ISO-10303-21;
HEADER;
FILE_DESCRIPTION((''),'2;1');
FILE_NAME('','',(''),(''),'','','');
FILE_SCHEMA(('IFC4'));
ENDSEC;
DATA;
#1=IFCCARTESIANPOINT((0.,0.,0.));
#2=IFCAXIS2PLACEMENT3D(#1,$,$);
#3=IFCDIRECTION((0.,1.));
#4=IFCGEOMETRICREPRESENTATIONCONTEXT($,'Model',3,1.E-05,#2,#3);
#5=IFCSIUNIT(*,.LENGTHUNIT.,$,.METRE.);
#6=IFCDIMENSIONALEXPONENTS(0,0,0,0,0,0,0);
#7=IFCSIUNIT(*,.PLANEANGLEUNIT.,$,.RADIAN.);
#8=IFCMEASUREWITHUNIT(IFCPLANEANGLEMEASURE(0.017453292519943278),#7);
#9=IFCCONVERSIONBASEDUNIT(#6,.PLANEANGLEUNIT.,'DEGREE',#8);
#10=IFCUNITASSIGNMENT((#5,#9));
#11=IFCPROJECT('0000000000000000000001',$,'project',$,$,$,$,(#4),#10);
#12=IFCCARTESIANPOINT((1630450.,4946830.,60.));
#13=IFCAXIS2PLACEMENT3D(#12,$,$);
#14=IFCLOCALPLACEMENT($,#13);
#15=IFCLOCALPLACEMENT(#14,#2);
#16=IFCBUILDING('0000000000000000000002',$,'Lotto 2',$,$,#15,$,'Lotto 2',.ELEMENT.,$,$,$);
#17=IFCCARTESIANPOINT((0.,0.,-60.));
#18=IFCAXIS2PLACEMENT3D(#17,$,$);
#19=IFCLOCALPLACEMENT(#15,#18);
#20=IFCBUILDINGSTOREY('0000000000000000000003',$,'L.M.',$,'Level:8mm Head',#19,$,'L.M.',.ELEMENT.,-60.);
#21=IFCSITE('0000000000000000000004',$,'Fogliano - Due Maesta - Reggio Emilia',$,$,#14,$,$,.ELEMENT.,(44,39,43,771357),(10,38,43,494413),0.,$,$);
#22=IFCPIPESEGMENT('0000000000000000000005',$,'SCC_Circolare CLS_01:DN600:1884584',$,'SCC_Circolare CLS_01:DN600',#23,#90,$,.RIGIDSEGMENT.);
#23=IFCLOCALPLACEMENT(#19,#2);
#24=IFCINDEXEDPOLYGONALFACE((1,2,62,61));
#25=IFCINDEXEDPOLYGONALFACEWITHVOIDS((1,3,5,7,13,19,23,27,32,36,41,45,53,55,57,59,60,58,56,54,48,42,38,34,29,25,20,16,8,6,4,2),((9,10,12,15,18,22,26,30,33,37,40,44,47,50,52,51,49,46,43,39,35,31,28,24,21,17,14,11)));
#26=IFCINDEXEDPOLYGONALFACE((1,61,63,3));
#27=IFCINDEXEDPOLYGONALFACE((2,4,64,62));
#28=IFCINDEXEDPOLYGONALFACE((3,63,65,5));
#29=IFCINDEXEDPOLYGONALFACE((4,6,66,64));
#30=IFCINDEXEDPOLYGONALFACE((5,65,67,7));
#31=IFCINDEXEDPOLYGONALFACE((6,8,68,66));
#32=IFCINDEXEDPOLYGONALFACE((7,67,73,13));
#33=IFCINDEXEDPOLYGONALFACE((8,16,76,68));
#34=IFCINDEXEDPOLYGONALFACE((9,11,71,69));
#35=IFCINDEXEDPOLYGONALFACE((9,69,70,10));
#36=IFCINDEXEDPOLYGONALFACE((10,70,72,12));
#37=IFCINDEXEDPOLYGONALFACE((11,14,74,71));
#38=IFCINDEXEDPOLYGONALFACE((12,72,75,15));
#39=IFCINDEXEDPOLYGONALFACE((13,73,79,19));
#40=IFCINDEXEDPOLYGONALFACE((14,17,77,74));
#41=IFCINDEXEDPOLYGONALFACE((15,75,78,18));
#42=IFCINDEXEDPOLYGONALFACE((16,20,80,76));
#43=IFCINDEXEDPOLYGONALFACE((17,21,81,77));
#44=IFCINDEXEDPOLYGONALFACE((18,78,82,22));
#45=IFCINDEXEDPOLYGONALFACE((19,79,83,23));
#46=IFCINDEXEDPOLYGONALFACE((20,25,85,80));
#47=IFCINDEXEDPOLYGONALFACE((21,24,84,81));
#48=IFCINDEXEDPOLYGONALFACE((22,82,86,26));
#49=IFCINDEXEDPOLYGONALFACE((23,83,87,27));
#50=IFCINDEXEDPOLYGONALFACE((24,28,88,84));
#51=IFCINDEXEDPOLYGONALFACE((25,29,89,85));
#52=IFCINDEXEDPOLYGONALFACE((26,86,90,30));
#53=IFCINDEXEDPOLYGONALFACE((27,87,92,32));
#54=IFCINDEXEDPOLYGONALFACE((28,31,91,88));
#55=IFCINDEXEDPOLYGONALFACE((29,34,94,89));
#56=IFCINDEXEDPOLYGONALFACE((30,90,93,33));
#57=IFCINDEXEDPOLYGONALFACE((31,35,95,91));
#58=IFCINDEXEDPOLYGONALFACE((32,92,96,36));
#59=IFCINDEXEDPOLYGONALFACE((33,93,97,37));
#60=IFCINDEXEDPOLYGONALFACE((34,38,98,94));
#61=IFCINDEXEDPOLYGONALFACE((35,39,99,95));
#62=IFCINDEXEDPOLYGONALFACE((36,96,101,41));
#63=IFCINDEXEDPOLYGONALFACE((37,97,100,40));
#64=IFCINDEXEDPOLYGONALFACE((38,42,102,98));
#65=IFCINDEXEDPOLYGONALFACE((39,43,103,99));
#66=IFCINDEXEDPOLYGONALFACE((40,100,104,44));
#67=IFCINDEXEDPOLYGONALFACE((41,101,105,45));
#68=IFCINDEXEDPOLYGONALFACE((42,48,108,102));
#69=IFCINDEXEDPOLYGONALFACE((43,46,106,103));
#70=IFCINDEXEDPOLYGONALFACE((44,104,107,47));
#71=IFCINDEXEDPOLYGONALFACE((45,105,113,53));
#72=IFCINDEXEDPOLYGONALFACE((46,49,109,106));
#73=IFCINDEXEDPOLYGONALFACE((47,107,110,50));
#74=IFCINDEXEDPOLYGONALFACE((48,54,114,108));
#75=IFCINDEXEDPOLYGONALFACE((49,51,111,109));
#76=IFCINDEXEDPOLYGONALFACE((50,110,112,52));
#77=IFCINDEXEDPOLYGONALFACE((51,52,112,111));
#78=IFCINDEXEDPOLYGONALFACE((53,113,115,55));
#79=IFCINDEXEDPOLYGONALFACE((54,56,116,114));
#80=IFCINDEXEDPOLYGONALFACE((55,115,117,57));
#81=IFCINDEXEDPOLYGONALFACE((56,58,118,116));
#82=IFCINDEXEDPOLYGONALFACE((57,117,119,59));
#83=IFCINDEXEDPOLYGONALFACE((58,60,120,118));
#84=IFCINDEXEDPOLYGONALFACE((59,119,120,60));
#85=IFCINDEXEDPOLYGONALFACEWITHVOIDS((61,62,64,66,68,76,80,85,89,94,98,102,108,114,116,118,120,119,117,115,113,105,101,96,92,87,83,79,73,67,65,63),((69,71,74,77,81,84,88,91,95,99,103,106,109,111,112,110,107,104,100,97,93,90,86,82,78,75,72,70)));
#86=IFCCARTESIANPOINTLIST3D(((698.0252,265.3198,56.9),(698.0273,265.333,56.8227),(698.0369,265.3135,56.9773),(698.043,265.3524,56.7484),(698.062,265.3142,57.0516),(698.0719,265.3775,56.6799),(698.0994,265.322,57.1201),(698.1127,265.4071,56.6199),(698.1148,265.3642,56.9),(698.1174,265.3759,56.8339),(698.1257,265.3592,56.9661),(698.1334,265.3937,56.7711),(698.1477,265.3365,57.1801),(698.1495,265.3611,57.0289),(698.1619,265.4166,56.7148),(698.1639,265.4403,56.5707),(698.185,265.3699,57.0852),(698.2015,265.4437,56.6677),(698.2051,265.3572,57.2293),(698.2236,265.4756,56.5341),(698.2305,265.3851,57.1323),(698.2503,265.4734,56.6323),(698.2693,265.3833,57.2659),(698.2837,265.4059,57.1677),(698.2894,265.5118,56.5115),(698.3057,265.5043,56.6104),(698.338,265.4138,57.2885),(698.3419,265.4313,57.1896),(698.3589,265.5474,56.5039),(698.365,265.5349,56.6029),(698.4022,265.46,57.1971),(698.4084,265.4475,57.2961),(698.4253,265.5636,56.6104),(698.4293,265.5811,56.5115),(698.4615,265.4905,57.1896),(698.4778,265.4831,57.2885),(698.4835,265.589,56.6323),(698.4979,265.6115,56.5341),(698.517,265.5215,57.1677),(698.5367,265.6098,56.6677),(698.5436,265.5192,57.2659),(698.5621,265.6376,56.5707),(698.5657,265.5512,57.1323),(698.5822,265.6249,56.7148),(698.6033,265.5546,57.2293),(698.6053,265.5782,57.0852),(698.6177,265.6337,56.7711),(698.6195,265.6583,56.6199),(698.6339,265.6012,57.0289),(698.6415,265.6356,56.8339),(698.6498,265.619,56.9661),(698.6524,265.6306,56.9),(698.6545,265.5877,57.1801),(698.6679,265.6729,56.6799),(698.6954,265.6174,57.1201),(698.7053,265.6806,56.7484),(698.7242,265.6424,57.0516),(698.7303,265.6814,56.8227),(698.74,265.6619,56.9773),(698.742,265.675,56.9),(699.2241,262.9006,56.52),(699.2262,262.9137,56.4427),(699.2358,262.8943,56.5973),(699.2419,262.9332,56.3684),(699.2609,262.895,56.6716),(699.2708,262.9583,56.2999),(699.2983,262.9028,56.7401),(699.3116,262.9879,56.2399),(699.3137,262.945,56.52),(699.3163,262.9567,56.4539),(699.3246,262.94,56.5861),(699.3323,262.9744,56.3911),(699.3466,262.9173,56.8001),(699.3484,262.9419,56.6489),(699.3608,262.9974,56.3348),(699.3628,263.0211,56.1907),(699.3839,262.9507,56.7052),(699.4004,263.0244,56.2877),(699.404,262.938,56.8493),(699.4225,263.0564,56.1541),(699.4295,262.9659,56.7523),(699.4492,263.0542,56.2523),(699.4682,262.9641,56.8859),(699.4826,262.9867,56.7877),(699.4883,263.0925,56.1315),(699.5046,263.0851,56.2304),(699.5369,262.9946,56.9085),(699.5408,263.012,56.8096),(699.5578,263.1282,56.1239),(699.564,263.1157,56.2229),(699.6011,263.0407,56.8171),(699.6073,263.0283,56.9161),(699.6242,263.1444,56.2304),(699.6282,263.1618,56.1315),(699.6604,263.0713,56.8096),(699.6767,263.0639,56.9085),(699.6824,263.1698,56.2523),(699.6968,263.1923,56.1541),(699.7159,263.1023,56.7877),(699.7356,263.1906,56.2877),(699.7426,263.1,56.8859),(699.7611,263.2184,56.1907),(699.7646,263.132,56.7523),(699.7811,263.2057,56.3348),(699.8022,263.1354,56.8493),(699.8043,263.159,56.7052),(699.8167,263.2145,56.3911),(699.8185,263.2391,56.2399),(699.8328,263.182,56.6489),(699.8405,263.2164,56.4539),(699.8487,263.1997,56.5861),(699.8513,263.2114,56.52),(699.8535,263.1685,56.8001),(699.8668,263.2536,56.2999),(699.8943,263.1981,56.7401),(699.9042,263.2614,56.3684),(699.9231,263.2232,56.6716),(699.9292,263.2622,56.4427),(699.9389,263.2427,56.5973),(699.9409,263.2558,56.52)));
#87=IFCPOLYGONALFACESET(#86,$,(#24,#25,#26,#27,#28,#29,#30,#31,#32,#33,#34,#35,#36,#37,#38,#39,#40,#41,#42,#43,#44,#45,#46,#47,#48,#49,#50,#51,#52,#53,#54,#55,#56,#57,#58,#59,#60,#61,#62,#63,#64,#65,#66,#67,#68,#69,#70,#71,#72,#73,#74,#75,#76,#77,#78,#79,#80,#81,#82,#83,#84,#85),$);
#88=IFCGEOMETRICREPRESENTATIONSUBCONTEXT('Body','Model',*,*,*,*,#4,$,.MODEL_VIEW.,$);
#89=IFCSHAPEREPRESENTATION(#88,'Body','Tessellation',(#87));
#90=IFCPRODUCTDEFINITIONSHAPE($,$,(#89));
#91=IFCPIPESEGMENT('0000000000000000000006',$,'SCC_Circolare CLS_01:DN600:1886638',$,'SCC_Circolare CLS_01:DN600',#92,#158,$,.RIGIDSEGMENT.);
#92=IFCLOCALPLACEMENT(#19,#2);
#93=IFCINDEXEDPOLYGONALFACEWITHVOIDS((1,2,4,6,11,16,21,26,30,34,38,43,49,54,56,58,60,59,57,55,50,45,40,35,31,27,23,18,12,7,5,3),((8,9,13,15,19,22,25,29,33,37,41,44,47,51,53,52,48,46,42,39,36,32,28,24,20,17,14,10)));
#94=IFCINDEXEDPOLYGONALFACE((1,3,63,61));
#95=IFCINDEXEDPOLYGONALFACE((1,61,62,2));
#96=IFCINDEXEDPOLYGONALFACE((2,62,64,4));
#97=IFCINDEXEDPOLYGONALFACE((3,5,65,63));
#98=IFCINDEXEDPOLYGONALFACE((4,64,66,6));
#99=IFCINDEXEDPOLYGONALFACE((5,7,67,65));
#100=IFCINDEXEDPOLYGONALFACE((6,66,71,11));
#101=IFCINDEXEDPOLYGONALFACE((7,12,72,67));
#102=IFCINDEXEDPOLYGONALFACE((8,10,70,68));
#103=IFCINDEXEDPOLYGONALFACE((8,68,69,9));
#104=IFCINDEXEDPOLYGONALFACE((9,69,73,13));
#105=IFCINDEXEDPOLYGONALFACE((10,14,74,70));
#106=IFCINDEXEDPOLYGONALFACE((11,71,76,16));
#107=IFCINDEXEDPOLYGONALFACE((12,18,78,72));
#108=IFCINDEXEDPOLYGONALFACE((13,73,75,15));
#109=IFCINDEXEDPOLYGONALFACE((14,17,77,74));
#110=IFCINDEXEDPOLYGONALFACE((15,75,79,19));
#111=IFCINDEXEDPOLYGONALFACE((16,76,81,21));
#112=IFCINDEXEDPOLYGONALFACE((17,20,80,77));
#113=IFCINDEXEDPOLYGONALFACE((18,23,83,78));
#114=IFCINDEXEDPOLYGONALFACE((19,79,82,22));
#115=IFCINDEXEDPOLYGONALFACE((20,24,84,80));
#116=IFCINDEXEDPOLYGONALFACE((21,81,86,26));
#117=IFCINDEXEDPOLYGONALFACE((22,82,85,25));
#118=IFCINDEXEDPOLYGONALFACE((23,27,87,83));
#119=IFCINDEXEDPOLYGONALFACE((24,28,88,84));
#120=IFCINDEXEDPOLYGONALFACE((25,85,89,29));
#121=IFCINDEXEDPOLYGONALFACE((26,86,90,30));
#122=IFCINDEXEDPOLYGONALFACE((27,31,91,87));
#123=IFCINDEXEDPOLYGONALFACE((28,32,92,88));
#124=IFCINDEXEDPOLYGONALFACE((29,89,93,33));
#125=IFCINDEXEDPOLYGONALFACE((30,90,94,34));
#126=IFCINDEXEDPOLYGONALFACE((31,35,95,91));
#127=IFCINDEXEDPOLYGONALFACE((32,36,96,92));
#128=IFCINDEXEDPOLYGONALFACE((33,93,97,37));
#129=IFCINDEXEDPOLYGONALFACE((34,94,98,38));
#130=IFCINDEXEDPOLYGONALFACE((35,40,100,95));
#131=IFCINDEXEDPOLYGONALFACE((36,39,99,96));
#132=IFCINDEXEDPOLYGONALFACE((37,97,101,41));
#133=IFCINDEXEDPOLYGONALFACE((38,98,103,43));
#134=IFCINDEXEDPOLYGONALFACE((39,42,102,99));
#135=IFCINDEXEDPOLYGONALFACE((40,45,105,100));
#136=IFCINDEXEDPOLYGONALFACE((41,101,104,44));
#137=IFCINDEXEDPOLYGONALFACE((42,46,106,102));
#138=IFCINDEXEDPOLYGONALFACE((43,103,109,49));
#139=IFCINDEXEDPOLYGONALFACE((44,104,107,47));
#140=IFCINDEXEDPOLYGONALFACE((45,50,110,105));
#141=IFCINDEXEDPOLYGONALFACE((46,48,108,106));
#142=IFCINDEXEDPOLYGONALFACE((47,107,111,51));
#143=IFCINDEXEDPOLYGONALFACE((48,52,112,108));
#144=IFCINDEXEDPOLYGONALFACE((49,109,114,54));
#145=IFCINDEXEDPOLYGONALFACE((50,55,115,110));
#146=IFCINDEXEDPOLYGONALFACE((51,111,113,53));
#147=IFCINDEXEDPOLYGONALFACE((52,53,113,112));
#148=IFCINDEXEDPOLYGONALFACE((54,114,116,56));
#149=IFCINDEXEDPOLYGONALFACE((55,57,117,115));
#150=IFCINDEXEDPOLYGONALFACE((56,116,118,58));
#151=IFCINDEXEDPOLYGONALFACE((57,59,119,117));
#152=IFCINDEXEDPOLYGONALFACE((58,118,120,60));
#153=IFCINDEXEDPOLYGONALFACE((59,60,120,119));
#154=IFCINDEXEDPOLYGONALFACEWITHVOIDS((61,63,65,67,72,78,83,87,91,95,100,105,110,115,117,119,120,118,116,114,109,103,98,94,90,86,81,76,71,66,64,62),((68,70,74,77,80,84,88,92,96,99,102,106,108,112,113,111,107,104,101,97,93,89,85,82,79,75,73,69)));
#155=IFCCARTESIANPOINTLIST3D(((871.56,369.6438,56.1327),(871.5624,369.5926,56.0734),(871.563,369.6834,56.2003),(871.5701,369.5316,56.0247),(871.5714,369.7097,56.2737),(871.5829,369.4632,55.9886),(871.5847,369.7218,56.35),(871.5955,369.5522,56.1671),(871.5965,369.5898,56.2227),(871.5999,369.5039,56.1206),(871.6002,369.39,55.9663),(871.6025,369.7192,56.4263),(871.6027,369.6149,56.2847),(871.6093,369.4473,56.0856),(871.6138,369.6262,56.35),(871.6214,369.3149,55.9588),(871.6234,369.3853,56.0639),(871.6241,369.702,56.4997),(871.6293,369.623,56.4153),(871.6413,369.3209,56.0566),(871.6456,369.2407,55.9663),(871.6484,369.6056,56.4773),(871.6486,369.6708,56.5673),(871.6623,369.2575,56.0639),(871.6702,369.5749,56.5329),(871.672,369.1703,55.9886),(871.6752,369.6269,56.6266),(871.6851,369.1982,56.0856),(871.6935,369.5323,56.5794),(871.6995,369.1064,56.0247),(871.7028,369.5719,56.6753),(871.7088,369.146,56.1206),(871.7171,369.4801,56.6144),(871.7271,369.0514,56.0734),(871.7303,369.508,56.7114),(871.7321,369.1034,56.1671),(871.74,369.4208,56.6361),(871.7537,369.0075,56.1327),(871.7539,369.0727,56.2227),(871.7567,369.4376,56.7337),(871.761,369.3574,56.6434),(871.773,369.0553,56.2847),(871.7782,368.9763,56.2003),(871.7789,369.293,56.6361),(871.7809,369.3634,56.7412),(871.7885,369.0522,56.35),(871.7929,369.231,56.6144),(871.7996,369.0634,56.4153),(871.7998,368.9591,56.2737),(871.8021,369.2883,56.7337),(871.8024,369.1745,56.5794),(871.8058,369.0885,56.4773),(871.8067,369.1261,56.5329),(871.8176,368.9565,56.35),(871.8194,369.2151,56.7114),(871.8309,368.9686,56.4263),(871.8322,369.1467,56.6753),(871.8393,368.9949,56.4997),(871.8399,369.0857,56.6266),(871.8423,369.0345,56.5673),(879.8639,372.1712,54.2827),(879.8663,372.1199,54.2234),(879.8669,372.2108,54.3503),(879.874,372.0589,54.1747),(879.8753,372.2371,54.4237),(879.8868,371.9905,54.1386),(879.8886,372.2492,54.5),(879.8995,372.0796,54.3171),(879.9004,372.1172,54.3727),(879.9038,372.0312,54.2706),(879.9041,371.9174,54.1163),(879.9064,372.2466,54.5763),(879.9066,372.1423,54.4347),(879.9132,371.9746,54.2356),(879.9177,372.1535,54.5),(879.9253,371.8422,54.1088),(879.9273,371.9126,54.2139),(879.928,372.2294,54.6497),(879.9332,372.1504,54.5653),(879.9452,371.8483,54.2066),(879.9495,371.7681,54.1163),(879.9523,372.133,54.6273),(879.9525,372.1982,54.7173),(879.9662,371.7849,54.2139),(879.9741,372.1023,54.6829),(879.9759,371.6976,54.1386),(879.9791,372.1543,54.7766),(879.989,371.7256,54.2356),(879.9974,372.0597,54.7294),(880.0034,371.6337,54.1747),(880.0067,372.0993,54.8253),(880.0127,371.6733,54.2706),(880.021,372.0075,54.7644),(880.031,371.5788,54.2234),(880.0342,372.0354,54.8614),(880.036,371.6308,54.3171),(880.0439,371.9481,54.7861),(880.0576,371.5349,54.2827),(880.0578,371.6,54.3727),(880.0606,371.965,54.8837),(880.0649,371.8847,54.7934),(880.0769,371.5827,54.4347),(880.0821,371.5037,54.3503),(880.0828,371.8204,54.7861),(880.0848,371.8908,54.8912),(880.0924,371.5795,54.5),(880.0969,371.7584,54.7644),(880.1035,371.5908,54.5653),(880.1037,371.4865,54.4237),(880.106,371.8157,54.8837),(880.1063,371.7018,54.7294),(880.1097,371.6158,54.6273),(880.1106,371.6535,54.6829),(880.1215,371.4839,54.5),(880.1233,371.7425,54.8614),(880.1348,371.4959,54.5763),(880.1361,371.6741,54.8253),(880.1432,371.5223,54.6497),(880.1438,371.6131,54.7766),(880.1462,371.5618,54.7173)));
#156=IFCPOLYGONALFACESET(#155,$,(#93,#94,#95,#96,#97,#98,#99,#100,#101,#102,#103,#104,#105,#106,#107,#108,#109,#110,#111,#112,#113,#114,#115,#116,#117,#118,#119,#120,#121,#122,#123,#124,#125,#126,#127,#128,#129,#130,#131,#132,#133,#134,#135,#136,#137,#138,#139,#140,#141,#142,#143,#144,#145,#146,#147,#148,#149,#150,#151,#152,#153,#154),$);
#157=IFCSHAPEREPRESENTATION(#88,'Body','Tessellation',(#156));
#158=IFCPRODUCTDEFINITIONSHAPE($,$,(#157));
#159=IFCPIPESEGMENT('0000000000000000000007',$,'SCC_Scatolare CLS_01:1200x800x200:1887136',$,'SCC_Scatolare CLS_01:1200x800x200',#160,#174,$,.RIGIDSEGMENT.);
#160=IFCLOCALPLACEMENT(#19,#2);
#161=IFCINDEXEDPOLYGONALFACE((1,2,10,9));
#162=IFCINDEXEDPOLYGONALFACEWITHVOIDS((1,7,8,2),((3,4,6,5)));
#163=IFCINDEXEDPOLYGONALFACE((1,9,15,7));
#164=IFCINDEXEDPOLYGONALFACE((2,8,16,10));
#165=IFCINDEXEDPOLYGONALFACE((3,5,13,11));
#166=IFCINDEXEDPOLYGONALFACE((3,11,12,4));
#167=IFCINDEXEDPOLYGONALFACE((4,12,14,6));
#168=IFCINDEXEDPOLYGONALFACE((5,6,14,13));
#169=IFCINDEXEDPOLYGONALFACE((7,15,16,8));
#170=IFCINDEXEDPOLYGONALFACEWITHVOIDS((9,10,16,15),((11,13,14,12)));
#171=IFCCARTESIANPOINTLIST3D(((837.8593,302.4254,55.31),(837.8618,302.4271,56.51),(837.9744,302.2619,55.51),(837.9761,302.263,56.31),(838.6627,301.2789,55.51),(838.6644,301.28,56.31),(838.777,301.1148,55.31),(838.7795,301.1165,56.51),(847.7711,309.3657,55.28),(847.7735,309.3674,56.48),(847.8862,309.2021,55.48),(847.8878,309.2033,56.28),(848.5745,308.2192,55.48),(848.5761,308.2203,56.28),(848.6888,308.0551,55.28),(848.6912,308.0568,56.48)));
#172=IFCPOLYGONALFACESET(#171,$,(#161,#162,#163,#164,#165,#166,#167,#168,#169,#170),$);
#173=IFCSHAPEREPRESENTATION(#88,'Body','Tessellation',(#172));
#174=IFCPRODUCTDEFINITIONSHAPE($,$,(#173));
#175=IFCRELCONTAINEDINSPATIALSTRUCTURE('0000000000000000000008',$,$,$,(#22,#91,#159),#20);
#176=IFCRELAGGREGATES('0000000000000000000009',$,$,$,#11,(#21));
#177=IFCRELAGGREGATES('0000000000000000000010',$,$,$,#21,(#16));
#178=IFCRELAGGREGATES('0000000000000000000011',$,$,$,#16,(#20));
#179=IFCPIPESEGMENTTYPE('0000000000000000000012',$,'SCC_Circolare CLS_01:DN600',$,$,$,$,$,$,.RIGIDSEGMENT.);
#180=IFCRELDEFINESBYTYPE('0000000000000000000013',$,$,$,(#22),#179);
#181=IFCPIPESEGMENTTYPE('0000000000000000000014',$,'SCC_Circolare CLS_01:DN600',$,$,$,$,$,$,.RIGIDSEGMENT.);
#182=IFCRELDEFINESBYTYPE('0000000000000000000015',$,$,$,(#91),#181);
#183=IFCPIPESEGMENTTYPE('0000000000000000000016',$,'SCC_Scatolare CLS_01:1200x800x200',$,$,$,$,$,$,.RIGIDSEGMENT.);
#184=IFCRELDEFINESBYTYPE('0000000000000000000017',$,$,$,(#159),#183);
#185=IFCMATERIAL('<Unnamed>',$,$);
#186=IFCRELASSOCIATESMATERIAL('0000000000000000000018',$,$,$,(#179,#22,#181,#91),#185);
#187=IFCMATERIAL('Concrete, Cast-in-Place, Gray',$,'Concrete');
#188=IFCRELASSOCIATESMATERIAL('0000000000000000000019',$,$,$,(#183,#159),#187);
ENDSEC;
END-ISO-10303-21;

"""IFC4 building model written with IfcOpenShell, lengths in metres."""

from ifc_helpers import new_model, entity, si_unit, converted_unit, direction, frame, origin, place, context, subcontext, project, spatial, arc, indexed_curve, outline, extrude, source, transform, mapped, material, type_object, type_shapes, element, save


model = new_model("IFC4")

# Units and contexts
model_context = context("Model", 3, precision=1e-05, world=origin(), true_north=direction((0.0, 1.0)))
body_context = subcontext(model_context, "Body", "Model", "MODEL_VIEW")
ifc_project = project(units=[si_unit("LENGTHUNIT", "METRE"), converted_unit("PLANEANGLEUNIT", "DEGREE", entity("IfcPlaneAngleMeasure", 0.017453292519943278), si_unit("PLANEANGLEUNIT", "RADIAN"), dimensions=[0, 0, 0, 0, 0, 0, 0])], contexts=[model_context])

# Site, building, storey
site_placement = place(None, frame((1630450.0, 4946830.0, 60.0)))
site = spatial("IfcSite", under=ifc_project, at=site_placement, Name="Fogliano - Due Maesta - Reggio Emilia", CompositionType="ELEMENT", RefLatitude=(44, 39, 43, 771357), RefLongitude=(10, 38, 43, 494413), RefElevation=0.0)
building_placement = place(site_placement, origin())
building = spatial("IfcBuilding", under=site, at=building_placement, Name="Lotto 2", LongName="Lotto 2", CompositionType="ELEMENT")
storey_placement = place(building_placement, frame((0.0, 0.0, -60.0)))
storey = spatial("IfcBuildingStorey", under=building, at=storey_placement, Name="L.M.", ObjectType="Level:8mm Head", LongName="L.M.", CompositionType="ELEMENT", Elevation=-60.0)

# Pipe segments
ifc_material_1 = material(Name="Concrete, Cast-in-Place, Gray", Category="Concrete")
ifc_material_2 = material(Name="<Unnamed>")
pipe_segment_type_1 = type_object("IfcPipeSegmentType", Name="SCC_Circolare CLS_01:DN600", PredefinedType="RIGIDSEGMENT", material=ifc_material_2)
shared_shape_1 = source(origin(), body_context, "Body", "SweptSolid", [
    extrude(outline(indexed_curve([(0.0, -0.4), (0.4, 0.0), (0.0, 0.4), (-0.4, 0.0)], segments=[arc(1, 2, 3), arc(3, 4, 1)], self_intersect=False), holes=[indexed_curve([(0.0, -0.3), (-0.3, 0.0), (0.0, 0.3), (0.3, 0.0)], segments=[arc(1, 2, 3), arc(3, 4, 1)], self_intersect=False)]), frame((-1.3633, 0.0, 0.0), z_axis=(1.0, 0.0, 0.0), x_axis=(0.0, 0.0, -1.0)), (0.0, 0.0, 1.0), 2.7266),
])
type_shapes(pipe_segment_type_1, [shared_shape_1])
pipe_segment_1_placement = place(storey_placement, frame((698.9831, 264.2878, 56.71), z_axis=(0.061885, -0.124874, 0.990241), x_axis=(0.43971, -0.887261, -0.139367)))
element("IfcPipeSegment", 1, at=pipe_segment_1_placement, inside=storey, type_object=pipe_segment_type_1, material=ifc_material_2, Name="SCC_Circolare CLS_01:DN600:1884584", ObjectType="SCC_Circolare CLS_01:DN600", PredefinedType="RIGIDSEGMENT", context=body_context, shape_type="MappedRepresentation", body=[
    mapped(shared_shape_1, transform((0.0, 0.0, 0.0), scale=1.0)),
])
pipe_segment_type_2 = type_object("IfcPipeSegmentType", Name="SCC_Circolare CLS_01:DN600", PredefinedType="RIGIDSEGMENT", material=ifc_material_2)
shared_shape_2 = source(origin(), body_context, "Body", "SweptSolid", [
    extrude(outline(indexed_curve([(0.0, -0.4), (0.4, 0.0), (0.0, 0.4), (-0.4, 0.0)], segments=[arc(1, 2, 3), arc(3, 4, 1)], self_intersect=False), holes=[indexed_curve([(0.0, -0.3), (-0.3, 0.0), (0.0, 0.3), (0.3, 0.0)], segments=[arc(1, 2, 3), arc(3, 4, 1)], self_intersect=False)]), frame((-4.4375, 0.0, 0.0), z_axis=(1.0, 0.0, 0.0), x_axis=(0.0, 0.0, -1.0)), (0.0, 0.0, 1.0), 8.875),
])
type_shapes(pipe_segment_type_2, [shared_shape_2])
pipe_segment_2_placement = place(storey_placement, frame((875.8531, 370.6028, 55.425), z_axis=(0.19942, 0.060695, 0.978033), x_axis=(0.935656, 0.284775, -0.208452)))
element("IfcPipeSegment", 2, at=pipe_segment_2_placement, inside=storey, type_object=pipe_segment_type_2, material=ifc_material_2, Name="SCC_Circolare CLS_01:DN600:1886638", ObjectType="SCC_Circolare CLS_01:DN600", PredefinedType="RIGIDSEGMENT", context=body_context, shape_type="MappedRepresentation", body=[
    mapped(shared_shape_2, transform((0.0, 0.0, 0.0), scale=1.0)),
])
pipe_segment_type_3 = type_object("IfcPipeSegmentType", Name="SCC_Scatolare CLS_01:1200x800x200", PredefinedType="RIGIDSEGMENT", material=ifc_material_1)
shared_shape_3 = source(origin(), body_context, "Body", "SweptSolid", [
    extrude(outline(indexed_curve([(-0.6, -0.8), (0.6, -0.8), (0.6, 0.8), (-0.6, 0.8), (-0.6, -0.8)], self_intersect=False), holes=[indexed_curve([(-0.4, -0.6), (-0.4, 0.6), (0.4, 0.6), (0.4, -0.6), (-0.4, -0.6)], self_intersect=False)]), frame((-6.05, 0.0, 0.0), z_axis=(1.0, 0.0, 0.0), x_axis=(0.0, 0.0, -1.0)), (0.0, 0.0, 1.0), 12.1),
])
type_shapes(pipe_segment_type_3, [shared_shape_3])
pipe_segment_3_placement = place(storey_placement, frame((843.2753, 305.2411, 55.895), z_axis=(0.002031, 0.001422, 0.999997), x_axis=(0.81915, 0.573575, -0.002479)))
element("IfcPipeSegment", 3, at=pipe_segment_3_placement, inside=storey, type_object=pipe_segment_type_3, material=ifc_material_1, Name="SCC_Scatolare CLS_01:1200x800x200:1887136", ObjectType="SCC_Scatolare CLS_01:1200x800x200", PredefinedType="RIGIDSEGMENT", context=body_context, shape_type="MappedRepresentation", body=[
    mapped(shared_shape_3, transform((0.0, 0.0, 0.0), scale=1.0)),
])

save(model, "model.ifc")
